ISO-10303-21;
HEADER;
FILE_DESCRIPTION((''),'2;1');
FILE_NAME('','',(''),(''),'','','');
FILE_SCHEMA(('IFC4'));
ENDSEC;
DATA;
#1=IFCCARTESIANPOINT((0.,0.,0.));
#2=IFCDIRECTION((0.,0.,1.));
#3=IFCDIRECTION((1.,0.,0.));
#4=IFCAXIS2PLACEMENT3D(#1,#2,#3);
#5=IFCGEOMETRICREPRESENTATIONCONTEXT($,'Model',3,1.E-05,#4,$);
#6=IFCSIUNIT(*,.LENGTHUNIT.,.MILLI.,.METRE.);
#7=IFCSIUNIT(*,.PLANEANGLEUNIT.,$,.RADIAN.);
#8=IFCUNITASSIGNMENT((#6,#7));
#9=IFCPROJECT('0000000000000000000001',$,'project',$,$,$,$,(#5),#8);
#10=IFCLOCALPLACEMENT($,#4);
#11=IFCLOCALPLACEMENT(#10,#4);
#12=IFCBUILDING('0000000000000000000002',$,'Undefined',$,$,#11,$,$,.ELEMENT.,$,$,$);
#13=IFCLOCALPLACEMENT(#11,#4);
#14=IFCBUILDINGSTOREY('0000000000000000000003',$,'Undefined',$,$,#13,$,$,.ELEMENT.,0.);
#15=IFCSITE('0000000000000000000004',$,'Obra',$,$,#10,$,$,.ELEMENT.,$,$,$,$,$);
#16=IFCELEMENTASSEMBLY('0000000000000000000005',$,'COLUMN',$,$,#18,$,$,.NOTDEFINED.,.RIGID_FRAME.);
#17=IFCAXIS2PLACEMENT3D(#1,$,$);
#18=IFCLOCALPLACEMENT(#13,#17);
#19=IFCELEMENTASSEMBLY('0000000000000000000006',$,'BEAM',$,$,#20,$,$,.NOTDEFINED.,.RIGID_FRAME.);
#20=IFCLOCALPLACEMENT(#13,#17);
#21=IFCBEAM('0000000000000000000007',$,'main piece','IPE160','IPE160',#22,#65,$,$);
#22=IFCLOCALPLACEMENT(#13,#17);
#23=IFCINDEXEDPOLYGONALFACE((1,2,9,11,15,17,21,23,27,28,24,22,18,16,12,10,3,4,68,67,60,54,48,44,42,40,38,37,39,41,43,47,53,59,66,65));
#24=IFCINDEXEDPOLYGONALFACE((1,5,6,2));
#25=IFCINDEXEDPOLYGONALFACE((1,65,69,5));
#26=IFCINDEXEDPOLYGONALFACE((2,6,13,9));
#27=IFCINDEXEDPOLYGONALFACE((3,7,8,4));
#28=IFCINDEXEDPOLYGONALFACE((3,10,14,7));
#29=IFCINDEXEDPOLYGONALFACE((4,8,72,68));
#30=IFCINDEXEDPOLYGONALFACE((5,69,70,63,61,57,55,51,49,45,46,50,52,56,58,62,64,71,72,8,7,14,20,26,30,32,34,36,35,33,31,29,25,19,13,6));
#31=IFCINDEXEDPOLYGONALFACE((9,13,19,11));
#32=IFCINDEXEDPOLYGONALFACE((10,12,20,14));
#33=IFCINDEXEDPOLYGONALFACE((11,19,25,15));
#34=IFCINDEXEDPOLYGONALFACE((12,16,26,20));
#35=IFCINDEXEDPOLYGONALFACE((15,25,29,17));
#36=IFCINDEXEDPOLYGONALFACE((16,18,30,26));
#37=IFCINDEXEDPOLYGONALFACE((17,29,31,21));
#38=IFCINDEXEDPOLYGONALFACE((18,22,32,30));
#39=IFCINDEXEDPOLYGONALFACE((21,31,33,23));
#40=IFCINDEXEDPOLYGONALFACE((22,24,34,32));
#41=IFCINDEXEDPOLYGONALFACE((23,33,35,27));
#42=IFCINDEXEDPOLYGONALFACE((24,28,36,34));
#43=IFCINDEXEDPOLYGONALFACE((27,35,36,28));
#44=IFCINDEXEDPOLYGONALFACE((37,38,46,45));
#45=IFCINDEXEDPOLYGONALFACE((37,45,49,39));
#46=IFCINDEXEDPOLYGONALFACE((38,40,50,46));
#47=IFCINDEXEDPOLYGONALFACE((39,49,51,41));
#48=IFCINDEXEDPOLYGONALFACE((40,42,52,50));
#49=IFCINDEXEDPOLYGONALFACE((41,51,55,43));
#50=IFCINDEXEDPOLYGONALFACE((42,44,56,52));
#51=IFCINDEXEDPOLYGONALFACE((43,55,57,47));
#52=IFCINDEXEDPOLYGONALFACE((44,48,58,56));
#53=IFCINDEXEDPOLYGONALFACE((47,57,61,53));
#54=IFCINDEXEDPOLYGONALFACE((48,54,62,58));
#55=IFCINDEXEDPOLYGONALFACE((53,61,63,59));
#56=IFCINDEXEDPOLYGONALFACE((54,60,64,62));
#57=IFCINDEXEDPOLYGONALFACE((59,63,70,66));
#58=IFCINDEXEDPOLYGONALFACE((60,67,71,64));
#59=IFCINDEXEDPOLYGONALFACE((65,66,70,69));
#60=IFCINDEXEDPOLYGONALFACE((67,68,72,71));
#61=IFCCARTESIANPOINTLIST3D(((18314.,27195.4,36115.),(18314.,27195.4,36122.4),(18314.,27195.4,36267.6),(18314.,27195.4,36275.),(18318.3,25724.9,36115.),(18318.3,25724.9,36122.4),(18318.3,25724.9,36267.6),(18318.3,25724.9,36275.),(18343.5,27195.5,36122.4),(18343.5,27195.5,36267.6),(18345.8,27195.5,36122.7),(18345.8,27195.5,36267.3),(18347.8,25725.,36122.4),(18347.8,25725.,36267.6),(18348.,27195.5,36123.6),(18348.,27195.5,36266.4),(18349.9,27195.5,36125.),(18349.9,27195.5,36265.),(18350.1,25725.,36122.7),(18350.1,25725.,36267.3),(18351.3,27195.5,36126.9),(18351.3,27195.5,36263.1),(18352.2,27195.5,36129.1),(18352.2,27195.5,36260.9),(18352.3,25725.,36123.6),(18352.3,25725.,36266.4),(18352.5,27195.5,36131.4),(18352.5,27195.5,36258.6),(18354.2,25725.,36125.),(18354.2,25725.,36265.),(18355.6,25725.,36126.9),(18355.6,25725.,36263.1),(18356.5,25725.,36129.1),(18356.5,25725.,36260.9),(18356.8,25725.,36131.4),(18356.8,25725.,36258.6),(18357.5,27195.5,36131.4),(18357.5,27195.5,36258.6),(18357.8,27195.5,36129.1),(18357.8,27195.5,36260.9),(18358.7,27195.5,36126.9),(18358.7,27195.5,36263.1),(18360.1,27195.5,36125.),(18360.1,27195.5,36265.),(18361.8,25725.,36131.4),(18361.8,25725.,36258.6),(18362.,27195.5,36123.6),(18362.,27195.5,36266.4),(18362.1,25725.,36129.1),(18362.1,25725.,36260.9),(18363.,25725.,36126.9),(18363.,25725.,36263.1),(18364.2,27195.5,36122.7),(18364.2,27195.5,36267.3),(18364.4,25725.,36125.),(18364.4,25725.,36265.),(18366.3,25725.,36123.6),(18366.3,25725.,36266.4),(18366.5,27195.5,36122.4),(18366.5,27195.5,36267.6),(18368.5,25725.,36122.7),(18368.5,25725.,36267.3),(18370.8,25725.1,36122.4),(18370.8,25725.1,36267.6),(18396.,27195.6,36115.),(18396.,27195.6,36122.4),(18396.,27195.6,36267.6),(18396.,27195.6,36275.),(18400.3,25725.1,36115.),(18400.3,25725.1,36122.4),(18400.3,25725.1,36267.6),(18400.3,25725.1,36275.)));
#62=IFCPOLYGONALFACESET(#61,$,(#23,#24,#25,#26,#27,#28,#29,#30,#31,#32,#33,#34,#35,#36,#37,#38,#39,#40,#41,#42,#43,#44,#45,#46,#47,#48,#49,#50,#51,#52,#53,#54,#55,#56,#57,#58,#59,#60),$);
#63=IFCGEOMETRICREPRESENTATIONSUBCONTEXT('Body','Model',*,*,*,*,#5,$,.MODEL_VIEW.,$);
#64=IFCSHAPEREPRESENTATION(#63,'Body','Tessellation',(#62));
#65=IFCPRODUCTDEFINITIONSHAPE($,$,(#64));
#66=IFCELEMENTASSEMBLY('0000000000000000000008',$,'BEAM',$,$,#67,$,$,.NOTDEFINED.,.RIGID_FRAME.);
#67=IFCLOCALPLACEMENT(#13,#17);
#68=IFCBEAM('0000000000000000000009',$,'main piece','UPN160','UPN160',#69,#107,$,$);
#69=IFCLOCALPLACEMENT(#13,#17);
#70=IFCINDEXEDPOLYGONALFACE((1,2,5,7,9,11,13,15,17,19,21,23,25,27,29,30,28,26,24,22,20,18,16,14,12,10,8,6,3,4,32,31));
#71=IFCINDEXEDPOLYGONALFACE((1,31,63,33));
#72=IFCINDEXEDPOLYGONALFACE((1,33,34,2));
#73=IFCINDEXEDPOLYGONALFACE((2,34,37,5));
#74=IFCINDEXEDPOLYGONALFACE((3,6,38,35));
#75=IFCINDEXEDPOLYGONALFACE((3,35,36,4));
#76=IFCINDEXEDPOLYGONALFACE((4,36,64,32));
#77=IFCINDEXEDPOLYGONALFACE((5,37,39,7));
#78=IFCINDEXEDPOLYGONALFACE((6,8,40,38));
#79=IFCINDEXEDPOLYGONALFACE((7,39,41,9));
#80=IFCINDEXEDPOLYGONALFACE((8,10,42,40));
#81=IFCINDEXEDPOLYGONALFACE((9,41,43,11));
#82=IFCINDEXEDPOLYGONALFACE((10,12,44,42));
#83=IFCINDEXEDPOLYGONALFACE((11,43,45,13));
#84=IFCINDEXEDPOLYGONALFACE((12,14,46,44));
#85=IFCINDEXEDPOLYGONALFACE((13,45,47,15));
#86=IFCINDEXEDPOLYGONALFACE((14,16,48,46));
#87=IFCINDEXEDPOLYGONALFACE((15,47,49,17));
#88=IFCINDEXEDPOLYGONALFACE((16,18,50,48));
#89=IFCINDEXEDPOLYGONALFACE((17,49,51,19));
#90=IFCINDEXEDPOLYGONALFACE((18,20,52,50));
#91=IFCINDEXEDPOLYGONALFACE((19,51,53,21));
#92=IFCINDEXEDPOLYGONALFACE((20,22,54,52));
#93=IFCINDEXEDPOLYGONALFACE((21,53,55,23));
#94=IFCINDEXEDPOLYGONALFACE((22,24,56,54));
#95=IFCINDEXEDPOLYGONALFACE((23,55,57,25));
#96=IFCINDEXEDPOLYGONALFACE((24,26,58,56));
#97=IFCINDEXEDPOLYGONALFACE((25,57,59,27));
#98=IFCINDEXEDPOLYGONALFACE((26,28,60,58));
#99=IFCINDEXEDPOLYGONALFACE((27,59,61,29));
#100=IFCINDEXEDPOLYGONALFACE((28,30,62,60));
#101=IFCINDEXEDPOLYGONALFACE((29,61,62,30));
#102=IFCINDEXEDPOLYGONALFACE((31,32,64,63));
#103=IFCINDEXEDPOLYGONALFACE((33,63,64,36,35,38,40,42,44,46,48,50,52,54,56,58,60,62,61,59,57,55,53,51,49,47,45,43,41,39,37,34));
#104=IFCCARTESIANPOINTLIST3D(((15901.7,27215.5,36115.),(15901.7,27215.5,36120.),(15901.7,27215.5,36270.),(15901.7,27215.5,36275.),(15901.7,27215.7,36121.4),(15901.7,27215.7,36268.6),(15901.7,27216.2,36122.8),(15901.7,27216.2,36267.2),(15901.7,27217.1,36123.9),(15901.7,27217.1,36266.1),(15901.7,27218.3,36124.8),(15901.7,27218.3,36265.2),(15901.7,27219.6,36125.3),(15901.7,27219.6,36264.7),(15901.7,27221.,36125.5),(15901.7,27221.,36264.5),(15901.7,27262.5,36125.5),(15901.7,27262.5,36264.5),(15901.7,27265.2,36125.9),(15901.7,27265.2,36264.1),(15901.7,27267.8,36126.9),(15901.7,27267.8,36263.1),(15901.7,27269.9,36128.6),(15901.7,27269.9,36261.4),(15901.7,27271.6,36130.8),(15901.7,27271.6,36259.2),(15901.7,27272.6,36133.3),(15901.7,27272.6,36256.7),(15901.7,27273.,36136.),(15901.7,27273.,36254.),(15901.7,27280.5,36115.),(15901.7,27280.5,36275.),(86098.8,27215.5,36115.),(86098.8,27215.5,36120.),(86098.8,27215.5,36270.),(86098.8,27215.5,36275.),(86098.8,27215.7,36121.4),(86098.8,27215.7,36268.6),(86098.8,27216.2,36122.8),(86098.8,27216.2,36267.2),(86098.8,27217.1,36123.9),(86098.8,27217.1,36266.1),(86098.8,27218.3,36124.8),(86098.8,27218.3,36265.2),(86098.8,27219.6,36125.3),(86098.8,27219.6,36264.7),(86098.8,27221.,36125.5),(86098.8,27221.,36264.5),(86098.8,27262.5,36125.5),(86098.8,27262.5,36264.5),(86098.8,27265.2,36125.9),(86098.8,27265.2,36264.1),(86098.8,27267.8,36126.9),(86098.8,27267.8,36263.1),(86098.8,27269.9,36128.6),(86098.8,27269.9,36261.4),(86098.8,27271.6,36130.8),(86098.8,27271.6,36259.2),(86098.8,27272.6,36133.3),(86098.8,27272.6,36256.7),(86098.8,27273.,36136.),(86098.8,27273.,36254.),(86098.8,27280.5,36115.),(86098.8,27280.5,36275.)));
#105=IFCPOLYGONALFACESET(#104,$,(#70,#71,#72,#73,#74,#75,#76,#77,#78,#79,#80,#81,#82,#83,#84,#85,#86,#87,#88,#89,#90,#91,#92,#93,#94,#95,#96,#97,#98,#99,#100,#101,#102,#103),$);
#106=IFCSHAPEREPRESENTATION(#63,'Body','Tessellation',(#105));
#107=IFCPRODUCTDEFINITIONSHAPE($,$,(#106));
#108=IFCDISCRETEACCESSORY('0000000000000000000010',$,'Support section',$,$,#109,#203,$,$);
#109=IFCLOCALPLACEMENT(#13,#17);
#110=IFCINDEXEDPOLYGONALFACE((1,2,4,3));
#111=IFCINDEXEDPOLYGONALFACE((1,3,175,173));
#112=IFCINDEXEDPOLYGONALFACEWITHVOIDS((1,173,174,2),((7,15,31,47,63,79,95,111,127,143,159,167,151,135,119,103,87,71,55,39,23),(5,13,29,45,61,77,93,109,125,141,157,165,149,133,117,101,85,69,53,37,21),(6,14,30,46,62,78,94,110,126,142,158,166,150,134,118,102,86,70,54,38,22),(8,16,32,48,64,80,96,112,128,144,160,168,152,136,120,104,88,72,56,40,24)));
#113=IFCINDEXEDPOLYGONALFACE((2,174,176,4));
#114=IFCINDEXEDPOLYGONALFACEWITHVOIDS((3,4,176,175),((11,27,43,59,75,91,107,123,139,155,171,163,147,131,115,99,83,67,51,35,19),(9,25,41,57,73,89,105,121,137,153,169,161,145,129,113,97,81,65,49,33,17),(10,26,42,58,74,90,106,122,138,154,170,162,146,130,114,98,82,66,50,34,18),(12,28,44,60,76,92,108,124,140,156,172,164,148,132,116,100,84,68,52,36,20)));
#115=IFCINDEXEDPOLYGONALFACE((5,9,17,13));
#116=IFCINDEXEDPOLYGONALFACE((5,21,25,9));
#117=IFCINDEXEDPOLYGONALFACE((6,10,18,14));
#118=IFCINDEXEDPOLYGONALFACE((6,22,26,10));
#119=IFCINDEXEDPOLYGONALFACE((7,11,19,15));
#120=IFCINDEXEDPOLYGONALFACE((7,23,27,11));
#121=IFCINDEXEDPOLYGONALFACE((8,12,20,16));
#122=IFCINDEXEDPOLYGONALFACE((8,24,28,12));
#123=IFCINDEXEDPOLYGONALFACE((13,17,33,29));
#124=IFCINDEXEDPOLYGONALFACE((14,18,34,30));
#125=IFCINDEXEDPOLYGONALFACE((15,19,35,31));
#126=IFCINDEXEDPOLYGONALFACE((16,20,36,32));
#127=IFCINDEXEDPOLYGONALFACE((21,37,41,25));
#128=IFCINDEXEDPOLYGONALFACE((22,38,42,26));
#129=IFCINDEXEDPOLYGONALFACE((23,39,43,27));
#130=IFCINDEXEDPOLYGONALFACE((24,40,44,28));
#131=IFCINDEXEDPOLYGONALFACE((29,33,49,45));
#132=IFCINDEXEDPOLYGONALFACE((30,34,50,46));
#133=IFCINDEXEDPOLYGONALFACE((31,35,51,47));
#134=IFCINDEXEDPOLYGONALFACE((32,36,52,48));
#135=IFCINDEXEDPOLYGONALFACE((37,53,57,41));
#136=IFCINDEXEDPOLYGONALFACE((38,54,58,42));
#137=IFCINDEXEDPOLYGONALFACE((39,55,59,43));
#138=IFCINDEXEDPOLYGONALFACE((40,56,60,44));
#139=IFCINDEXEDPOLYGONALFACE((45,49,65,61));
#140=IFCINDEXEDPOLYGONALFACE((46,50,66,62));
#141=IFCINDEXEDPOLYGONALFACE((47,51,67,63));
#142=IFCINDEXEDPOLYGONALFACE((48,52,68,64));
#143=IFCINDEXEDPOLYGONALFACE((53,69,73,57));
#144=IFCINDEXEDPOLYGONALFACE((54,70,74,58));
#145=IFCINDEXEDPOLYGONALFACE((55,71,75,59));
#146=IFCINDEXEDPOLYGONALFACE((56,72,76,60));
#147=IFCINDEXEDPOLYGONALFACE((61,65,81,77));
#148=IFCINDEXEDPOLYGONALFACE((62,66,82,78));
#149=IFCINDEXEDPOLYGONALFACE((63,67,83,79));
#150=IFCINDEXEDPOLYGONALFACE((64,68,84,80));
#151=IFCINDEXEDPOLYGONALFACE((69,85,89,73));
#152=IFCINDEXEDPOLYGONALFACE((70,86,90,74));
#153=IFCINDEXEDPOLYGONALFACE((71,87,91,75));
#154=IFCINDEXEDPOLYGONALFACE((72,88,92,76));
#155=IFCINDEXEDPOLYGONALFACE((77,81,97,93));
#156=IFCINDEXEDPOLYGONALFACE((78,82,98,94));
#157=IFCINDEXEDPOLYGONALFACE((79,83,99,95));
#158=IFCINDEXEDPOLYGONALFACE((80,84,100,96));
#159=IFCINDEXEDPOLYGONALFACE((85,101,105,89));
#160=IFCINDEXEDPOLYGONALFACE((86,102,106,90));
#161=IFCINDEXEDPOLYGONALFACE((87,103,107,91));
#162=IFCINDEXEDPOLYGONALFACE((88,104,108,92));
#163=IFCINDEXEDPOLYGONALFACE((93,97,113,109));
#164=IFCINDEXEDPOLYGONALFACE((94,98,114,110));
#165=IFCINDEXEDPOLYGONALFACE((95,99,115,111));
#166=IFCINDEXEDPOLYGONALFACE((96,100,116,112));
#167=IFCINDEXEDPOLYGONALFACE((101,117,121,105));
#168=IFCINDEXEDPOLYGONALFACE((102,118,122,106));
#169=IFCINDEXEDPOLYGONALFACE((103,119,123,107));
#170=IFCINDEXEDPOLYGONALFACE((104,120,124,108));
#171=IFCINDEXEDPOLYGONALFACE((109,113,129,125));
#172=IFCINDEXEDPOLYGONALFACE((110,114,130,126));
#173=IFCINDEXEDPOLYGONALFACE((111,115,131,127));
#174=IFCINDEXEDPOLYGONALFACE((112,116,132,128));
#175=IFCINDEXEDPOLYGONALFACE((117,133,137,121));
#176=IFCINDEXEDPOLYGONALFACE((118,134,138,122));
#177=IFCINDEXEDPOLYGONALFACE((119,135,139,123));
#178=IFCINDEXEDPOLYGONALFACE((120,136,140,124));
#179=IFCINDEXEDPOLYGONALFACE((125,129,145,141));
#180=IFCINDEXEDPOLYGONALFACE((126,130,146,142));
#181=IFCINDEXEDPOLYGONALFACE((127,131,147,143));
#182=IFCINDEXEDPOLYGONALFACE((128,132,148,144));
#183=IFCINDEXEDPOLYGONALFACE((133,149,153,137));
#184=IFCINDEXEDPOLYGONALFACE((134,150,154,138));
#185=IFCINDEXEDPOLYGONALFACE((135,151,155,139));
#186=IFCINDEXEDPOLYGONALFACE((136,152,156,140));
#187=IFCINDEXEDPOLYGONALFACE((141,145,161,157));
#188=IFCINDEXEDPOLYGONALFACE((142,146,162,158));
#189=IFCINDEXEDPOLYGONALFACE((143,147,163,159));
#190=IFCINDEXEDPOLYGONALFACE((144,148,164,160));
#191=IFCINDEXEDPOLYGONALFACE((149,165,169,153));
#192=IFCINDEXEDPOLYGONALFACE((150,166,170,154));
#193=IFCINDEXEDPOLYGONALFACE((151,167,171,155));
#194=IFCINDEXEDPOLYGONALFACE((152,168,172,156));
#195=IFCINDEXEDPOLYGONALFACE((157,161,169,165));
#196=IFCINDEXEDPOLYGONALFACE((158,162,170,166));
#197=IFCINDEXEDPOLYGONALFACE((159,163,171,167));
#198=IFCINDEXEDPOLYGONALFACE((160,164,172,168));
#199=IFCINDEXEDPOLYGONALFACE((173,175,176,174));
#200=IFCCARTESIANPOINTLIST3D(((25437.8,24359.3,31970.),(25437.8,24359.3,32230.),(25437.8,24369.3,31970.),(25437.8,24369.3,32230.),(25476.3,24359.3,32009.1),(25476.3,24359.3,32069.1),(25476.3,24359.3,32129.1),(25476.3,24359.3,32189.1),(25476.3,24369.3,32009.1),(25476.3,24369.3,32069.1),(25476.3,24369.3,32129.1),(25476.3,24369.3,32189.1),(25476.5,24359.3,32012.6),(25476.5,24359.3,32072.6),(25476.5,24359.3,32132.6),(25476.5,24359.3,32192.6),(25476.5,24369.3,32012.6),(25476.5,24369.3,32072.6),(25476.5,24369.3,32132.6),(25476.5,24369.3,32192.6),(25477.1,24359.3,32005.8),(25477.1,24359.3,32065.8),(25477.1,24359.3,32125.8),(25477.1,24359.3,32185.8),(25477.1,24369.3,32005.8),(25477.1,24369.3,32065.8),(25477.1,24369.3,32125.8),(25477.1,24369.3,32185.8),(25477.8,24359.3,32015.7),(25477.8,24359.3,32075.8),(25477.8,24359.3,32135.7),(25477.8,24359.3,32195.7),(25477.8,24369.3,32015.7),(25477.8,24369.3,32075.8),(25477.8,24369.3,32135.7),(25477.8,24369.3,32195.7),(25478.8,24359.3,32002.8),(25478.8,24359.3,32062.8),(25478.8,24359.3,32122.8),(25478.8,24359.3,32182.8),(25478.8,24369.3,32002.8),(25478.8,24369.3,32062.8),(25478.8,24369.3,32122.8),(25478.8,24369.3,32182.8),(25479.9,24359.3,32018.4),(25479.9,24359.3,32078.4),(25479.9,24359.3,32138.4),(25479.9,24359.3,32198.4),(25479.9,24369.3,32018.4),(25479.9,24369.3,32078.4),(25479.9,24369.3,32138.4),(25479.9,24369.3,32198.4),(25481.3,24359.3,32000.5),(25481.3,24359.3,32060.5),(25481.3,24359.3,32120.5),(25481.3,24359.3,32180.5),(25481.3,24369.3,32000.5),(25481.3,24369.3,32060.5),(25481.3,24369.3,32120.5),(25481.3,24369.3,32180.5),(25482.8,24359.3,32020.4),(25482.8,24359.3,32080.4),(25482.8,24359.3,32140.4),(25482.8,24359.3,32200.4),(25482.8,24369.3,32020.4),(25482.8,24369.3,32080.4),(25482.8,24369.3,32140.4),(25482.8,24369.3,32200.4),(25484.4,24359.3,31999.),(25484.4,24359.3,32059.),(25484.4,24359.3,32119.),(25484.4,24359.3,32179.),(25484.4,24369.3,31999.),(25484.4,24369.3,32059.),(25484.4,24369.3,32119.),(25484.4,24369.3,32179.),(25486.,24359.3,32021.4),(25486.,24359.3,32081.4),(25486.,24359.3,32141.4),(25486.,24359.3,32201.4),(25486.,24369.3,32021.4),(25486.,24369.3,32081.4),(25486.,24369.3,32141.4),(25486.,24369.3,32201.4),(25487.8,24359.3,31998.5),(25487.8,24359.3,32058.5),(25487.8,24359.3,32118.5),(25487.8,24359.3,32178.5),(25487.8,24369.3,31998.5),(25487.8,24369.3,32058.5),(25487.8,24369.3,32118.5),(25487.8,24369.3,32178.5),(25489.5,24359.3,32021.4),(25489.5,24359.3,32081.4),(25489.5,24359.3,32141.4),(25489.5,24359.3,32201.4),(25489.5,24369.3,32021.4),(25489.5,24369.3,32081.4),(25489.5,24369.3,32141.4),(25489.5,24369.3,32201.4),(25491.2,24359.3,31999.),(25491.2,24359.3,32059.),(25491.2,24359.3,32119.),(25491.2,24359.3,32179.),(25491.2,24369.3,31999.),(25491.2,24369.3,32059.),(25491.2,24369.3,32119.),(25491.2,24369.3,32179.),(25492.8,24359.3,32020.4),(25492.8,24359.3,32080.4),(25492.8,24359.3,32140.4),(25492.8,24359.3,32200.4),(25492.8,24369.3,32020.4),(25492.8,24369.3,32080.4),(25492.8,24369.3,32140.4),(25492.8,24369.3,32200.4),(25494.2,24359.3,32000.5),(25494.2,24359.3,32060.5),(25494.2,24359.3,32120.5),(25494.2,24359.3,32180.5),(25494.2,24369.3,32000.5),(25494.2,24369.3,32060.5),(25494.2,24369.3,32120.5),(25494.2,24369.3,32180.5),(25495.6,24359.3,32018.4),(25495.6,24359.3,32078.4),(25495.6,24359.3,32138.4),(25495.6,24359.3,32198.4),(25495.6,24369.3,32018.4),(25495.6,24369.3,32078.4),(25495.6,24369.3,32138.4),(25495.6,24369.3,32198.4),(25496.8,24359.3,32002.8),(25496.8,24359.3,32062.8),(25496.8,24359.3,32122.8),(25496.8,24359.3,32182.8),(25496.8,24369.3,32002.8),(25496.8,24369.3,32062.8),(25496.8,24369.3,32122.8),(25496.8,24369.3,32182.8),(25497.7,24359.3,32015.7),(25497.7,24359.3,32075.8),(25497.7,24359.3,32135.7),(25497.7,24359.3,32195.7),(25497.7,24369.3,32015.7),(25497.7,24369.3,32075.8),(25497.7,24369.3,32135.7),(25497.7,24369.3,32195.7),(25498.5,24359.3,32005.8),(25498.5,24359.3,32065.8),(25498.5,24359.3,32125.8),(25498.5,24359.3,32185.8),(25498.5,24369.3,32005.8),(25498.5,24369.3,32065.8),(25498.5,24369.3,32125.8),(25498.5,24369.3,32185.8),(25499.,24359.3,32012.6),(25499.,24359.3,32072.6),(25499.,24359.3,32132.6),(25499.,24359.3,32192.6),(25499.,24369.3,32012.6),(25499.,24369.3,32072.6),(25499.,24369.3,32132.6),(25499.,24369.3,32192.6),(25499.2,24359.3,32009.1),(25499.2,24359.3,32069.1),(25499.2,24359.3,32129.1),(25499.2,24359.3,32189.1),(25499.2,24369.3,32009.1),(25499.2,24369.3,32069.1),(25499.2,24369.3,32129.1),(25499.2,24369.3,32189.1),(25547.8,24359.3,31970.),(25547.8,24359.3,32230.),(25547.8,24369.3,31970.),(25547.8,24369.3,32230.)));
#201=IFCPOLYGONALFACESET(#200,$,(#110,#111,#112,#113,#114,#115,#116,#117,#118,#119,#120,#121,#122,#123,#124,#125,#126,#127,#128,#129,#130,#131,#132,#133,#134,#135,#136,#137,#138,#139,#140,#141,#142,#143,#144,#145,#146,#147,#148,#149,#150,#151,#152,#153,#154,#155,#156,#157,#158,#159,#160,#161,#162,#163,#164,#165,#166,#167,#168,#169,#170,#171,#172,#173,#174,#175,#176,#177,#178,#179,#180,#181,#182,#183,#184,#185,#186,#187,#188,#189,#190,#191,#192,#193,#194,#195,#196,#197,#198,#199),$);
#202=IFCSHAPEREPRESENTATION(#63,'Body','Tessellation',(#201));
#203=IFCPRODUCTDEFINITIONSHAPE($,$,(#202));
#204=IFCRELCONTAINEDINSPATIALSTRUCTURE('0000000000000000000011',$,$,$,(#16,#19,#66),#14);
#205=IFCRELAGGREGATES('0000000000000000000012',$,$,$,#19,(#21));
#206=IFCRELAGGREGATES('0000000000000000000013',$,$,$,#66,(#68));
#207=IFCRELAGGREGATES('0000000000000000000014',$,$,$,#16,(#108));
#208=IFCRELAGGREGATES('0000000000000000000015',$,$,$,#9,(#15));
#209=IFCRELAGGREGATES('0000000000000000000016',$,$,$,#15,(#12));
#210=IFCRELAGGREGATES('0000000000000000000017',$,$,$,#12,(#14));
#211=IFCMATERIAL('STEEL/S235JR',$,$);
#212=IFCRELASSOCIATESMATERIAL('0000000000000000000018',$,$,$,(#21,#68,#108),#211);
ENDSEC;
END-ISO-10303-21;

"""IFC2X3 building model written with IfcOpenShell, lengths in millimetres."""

from ifc_helpers import new_model, si_unit, frame, origin_with_axes, origin_2d_with_axis, place, context, subcontext, project, spatial, rectangle, circle, i_section, u_section, extrude, source, transform, mapped, material, element, aggregate, save


model = new_model("IFC2X3")

# Units and contexts
model_context = context("Model", 3, precision=1e-05, world=origin_with_axes())
body_context = subcontext(model_context, "Body", "Model", "MODEL_VIEW")
ifc_project = project(units=[si_unit("LENGTHUNIT", "METRE", prefix="MILLI"), si_unit("PLANEANGLEUNIT", "RADIAN")], contexts=[model_context])

# Site, building, storey
site_placement = place(None, origin_with_axes())
site = spatial("IfcSite", under=ifc_project, at=site_placement, Name="Obra", CompositionType="ELEMENT")
building_placement = place(site_placement, origin_with_axes())
building = spatial("IfcBuilding", under=site, at=building_placement, Name="Undefined", CompositionType="ELEMENT")
storey_placement = place(building_placement, origin_with_axes())
storey = spatial("IfcBuildingStorey", under=building, at=storey_placement, Name="Undefined", CompositionType="ELEMENT", Elevation=0.0)

# Element assembly
ifc_material_1 = material(Name="STEEL/S235JR")
assembly_1_placement = place(storey_placement, origin_with_axes())
assembly_1 = element("IfcElementAssembly", 1, at=assembly_1_placement, inside=storey, Name="COLUMN", AssemblyPlace="NOTDEFINED", PredefinedType="RIGID_FRAME")

# Element assemblies, beams
assembly_2_placement = place(storey_placement, origin_with_axes())
assembly_2 = element("IfcElementAssembly", 2, at=assembly_2_placement, inside=storey, Name="BEAM", AssemblyPlace="NOTDEFINED", PredefinedType="RIGID_FRAME")
beam_1_placement = place(assembly_2_placement, frame((18359.3, 25725.0, 36195.0), z_axis=(0.0, 0.0, 1.0), x_axis=(-0.002927, 0.999996, 0.0)))
beam_1 = element("IfcBeam", 3, at=beam_1_placement, material=ifc_material_1, Name="main piece", Description="IPE160", ObjectType="IPE160", context=body_context, shape_type="SweptSolid", body=[
    extrude(i_section(OverallWidth=82.0, OverallDepth=160.0, WebThickness=5.0, FlangeThickness=7.4, FilletRadius=9.0, at=origin_2d_with_axis()), frame((1470.5, 0.0, 0.0), z_axis=(-1.0, 0.0, 0.0), x_axis=(0.0, -1.0, 0.0)), (0.0, 0.0, 1.0), 1470.5),
])
aggregate(assembly_2, [beam_1])
assembly_3_placement = place(storey_placement, origin_with_axes())
assembly_3 = element("IfcElementAssembly", 4, at=assembly_3_placement, inside=storey, Name="BEAM", AssemblyPlace="NOTDEFINED", PredefinedType="RIGID_FRAME")
beam_2_placement = place(assembly_3_placement, frame((15901.7, 27248.0, 36195.0), z_axis=(0.0, 0.0, 1.0), x_axis=(1.0, 0.0, 0.0)))
beam_2 = element("IfcBeam", 5, at=beam_2_placement, material=ifc_material_1, Name="main piece", Description="UPN160", ObjectType="UPN160", context=body_context, shape_type="SweptSolid", body=[
    extrude(u_section(Depth=160.0, FlangeWidth=65.0, WebThickness=7.5, FlangeThickness=10.5, FilletRadius=10.5, EdgeRadius=5.5, at=origin_2d_with_axis()), frame((70197.1, 0.0, 0.0), z_axis=(-1.0, 0.0, 0.0), x_axis=(0.0, -1.0, 0.0)), (0.0, 0.0, 1.0), 70197.1),
])
aggregate(assembly_3, [beam_2])

# Discrete accessory, opening
discrete_accessory_1_placement = place(assembly_1_placement, frame((25492.8, 24364.3, 31970.0), z_axis=(0.0, 0.0, 1.0), x_axis=(1.0, 0.0, 0.0)))
discrete_accessory_1 = element("IfcDiscreteAccessory", 6, at=discrete_accessory_1_placement, material=ifc_material_1, Name="Support section", context=body_context, shape_type="SweptSolid", body=[
    extrude(rectangle(XDim=10.0, YDim=110.0, at=origin_2d_with_axis()), frame((0.0, 0.0, 260.0), z_axis=(0.0, 0.0, -1.0), x_axis=(0.0, 1.0, 0.0)), (0.0, 0.0, 1.0), 260.0),
])
shared_shape_1 = source(origin_with_axes(), body_context, "Body", "SweptSolid", [
    extrude(circle(Radius=11.5, at=origin_2d_with_axis()), frame((0.0, -14.4, 0.0), z_axis=(0.0, 1.0, 0.0), x_axis=(1.0, 0.0, 0.0)), (0.0, 0.0, 1.0), 10.2),
])
opening_1_placement = place(assembly_1_placement, frame((25537.8, 24355.0, 32300.0), z_axis=(-1.0, 0.0, 0.0), x_axis=(0.0, 0.0, -1.0)))
element("IfcOpeningElement", 7, at=opening_1_placement, cuts=discrete_accessory_1, ObjectType="Opening", context=body_context, shape_type="MappedRepresentation", body=[
    mapped(shared_shape_1, transform((110.0, 0.0, 50.0))),
    mapped(shared_shape_1, transform((170.0, 0.0, 50.0))),
    mapped(shared_shape_1, transform((230.0, 0.0, 50.0))),
    mapped(shared_shape_1, transform((290.0, 0.0, 50.0))),
])
aggregate(assembly_1, [discrete_accessory_1])

save(model, "model.ifc")
